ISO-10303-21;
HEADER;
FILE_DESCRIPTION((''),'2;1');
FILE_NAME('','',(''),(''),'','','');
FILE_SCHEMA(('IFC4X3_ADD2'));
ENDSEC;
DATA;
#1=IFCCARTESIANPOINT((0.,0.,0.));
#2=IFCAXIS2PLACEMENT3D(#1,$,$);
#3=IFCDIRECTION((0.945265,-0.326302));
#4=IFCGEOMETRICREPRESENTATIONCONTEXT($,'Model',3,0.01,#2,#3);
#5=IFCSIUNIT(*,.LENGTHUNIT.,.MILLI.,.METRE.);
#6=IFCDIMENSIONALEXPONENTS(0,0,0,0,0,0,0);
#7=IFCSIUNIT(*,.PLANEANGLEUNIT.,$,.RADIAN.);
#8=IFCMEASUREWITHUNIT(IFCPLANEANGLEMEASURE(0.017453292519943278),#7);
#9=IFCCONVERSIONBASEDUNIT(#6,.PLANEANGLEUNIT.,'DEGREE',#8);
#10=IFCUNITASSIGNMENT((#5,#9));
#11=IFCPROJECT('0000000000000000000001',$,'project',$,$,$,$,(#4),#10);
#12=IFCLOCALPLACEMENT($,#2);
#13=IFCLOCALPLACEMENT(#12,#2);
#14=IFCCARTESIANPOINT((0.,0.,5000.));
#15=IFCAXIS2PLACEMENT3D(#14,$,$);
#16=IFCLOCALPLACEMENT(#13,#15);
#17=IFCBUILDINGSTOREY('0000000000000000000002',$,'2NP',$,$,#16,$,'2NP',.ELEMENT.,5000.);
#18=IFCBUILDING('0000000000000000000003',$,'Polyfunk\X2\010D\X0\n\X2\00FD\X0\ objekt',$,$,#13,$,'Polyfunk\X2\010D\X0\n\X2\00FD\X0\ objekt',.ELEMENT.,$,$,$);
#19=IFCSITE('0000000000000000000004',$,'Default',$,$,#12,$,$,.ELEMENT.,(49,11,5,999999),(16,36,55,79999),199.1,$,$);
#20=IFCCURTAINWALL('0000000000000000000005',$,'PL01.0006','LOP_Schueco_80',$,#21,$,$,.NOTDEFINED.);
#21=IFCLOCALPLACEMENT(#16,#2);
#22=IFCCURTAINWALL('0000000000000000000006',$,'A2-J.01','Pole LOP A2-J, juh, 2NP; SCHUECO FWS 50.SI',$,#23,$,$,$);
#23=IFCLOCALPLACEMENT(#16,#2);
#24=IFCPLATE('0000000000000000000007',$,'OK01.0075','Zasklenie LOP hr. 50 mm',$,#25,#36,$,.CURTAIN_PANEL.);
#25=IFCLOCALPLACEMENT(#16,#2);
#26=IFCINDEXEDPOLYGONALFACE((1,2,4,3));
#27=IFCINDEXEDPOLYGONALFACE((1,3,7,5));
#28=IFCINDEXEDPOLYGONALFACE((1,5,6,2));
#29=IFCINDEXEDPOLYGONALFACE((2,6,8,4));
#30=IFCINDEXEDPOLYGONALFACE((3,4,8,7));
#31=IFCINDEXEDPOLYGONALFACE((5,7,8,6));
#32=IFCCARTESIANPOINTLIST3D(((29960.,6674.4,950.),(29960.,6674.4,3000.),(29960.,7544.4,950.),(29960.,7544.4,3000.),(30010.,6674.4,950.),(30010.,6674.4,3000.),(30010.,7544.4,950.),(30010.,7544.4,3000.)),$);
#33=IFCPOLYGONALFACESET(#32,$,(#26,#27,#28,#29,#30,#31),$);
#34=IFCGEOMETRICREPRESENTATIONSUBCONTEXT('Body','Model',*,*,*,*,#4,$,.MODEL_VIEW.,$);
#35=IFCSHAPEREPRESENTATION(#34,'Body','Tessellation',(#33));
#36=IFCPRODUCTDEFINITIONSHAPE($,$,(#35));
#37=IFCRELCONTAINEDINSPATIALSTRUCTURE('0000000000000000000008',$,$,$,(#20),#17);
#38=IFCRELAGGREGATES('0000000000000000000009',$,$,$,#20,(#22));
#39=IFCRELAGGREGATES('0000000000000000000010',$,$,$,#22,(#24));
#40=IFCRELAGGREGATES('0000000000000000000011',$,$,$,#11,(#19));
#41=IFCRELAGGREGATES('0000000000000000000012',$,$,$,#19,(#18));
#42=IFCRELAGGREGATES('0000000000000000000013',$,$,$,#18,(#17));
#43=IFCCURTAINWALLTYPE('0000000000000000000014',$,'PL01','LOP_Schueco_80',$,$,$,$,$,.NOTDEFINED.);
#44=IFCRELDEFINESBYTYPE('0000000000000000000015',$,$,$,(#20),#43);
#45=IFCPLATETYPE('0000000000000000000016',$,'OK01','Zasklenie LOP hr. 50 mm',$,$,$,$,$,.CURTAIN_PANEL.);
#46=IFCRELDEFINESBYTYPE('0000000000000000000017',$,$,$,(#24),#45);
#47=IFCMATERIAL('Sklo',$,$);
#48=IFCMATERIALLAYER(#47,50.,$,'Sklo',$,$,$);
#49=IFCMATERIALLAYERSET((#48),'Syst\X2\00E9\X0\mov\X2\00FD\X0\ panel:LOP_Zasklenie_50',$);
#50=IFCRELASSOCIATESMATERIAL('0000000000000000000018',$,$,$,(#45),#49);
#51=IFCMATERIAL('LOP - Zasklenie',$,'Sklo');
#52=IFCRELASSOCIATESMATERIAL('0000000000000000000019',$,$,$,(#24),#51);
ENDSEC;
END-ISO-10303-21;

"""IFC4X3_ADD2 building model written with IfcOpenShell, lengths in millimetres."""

from ifc_helpers import new_model, entity, si_unit, converted_unit, direction, frame, origin, origin_2d_with_axis, place, context, subcontext, project, spatial, rectangle, extrude, source, transform, mapped, material, layer, layer_set, type_object, element, aggregate, save


model = new_model("IFC4X3_ADD2")

# Units and contexts
model_context = context("Model", 3, precision=0.01, world=origin(), true_north=direction((0.945265, -0.326302)))
body_context = subcontext(model_context, "Body", "Model", "MODEL_VIEW")
ifc_project = project(units=[si_unit("LENGTHUNIT", "METRE", prefix="MILLI"), converted_unit("PLANEANGLEUNIT", "DEGREE", entity("IfcPlaneAngleMeasure", 0.017453292519943278), si_unit("PLANEANGLEUNIT", "RADIAN"), dimensions=[0, 0, 0, 0, 0, 0, 0])], contexts=[model_context])

# Site, building, storey
site_placement = place(None, origin())
site = spatial("IfcSite", under=ifc_project, at=site_placement, Name="Default", CompositionType="ELEMENT", RefLatitude=(49, 11, 5, 999999), RefLongitude=(16, 36, 55, 79999), RefElevation=199.1)
building_placement = place(site_placement, origin())
building = spatial("IfcBuilding", under=site, at=building_placement, Name="Polyfunkčný objekt", LongName="Polyfunkčný objekt", CompositionType="ELEMENT")
storey_placement = place(building_placement, frame((0.0, 0.0, 5000.0)))
storey = spatial("IfcBuildingStorey", under=building, at=storey_placement, Name="2NP", LongName="2NP", CompositionType="ELEMENT", Elevation=5000.0)

# Shared definitions
curtain_wall_type = type_object("IfcCurtainWallType", Name="PL01", Description="LOP_Schueco_80", PredefinedType="NOTDEFINED")

# Curtain walls, plate
curtain_wall_1_placement = place(storey_placement, frame((0.0, 0.0, -5000.0)))
curtain_wall_1 = element("IfcCurtainWall", 1, at=curtain_wall_1_placement, inside=storey, type_object=curtain_wall_type, Name="PL01.0006", Description="LOP_Schueco_80", PredefinedType="NOTDEFINED")
curtain_wall_2 = element("IfcCurtainWall", 2, Name="A2-J.01", Description="Pole LOP A2-J, juh, 2NP; SCHUECO FWS 50.SI")
aggregate(curtain_wall_1, [curtain_wall_2])
ifc_material_1 = material(Name="LOP - Zasklenie", Category="Sklo")
ifc_material_2 = material(Name="Sklo")
ifc_layer_1 = layer(ifc_material_2, 50.0, Name="Sklo")
ifc_layer_set_1 = layer_set([ifc_layer_1], Name="Systémový panel:LOP_Zasklenie_50")
plate_type_1 = type_object("IfcPlateType", Name="OK01", Description="Zasklenie LOP hr. 50 mm", PredefinedType="CURTAIN_PANEL", material=ifc_layer_set_1)
shared_shape_1 = source(origin(), body_context, "Body", "SweptSolid", [
    extrude(rectangle(XDim=50.0, YDim=870.0, at=origin_2d_with_axis()), frame((0.0, -25.0, 0.0), z_axis=(0.0, 0.0, 1.0), x_axis=(0.0, 1.0, 0.0)), (0.0, 0.0, 1.0), 2050.0),
])
plate_1_placement = place(curtain_wall_1_placement, frame((30010.0, 7109.4, 5950.0), z_axis=(0.0, 0.0, 1.0), x_axis=(0.0, -1.0, 0.0)))
plate_1 = element("IfcPlate", 3, at=plate_1_placement, type_object=plate_type_1, material=ifc_material_1, Name="OK01.0075", Description="Zasklenie LOP hr. 50 mm", PredefinedType="CURTAIN_PANEL", context=body_context, shape_type="MappedRepresentation", body=[
    mapped(shared_shape_1, transform((0.0, 0.0, 0.0), scale=1.0)),
])
aggregate(curtain_wall_2, [plate_1])

save(model, "model.ifc")
